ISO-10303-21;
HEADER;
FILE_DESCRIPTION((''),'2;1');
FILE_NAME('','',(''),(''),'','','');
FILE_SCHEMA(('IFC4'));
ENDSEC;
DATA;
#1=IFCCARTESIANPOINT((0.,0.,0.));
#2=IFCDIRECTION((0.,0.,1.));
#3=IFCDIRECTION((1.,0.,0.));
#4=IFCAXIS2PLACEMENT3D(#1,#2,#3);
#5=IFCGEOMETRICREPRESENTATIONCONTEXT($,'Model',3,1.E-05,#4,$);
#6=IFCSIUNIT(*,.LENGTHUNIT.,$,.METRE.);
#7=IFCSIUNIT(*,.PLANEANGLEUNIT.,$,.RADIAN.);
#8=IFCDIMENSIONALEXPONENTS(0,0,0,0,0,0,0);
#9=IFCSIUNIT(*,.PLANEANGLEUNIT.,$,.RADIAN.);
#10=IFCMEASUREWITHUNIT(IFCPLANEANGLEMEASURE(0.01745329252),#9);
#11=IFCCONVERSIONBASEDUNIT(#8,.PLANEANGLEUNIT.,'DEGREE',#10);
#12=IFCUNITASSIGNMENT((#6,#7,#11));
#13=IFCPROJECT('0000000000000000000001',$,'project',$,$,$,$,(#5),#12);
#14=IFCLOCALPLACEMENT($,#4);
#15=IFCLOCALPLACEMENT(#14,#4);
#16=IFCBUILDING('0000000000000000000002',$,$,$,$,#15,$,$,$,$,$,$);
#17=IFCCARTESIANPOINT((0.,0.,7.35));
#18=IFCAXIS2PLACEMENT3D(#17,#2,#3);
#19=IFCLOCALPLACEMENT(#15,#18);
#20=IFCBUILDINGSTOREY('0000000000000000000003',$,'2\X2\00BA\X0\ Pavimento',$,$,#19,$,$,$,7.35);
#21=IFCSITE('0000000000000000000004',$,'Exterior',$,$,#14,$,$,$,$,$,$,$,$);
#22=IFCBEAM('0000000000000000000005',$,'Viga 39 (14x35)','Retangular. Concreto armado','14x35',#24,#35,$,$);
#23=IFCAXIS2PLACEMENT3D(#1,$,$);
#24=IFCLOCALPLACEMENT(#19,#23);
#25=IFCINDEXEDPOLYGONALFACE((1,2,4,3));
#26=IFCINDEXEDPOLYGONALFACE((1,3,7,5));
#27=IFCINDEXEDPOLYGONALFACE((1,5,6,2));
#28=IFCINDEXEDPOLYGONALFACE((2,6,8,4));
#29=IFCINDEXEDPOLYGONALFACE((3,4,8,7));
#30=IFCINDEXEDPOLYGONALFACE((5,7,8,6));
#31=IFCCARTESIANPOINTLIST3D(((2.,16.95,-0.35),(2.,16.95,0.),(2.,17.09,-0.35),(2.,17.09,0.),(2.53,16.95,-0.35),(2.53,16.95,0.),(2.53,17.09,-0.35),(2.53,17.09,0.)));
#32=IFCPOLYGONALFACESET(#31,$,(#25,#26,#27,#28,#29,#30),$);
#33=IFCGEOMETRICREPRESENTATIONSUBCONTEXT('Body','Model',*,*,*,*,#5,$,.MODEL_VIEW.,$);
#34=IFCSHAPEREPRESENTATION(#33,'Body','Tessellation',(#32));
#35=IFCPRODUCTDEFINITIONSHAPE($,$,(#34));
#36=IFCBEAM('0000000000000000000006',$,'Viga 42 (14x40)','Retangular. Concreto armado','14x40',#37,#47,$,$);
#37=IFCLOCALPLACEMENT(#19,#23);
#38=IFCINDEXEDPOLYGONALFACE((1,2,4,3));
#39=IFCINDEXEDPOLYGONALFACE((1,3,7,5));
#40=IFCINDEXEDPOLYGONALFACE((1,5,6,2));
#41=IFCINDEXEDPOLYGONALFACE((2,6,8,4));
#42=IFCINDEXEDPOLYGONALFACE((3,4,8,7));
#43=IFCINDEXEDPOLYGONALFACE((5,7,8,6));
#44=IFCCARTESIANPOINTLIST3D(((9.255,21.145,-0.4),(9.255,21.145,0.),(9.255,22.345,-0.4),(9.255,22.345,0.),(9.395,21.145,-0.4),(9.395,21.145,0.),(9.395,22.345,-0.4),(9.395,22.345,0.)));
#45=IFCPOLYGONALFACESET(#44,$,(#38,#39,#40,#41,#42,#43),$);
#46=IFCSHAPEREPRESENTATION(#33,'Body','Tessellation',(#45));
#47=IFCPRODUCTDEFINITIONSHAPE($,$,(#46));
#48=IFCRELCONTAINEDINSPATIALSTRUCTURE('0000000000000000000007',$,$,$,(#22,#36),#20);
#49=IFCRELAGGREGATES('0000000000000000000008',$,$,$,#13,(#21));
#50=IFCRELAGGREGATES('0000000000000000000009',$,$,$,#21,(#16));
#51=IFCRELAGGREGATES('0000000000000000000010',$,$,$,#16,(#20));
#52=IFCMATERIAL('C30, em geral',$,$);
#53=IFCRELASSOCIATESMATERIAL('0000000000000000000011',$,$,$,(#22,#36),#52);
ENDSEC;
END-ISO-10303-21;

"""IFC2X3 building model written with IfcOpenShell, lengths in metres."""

from ifc_helpers import new_model, entity, si_unit, converted_unit, frame, frame_2d, origin_with_axes, place, context, subcontext, project, spatial, rectangle, extrude, material, element, save


model = new_model("IFC2X3")

# Units and contexts
model_context = context("Model", 3, precision=1e-05, world=origin_with_axes())
body_context = subcontext(model_context, "Body", "Model", "MODEL_VIEW")
ifc_project = project(units=[si_unit("LENGTHUNIT", "METRE"), si_unit("PLANEANGLEUNIT", "RADIAN"), converted_unit("PLANEANGLEUNIT", "DEGREE", entity("IfcPlaneAngleMeasure", 0.01745329252), si_unit("PLANEANGLEUNIT", "RADIAN"), dimensions=[0, 0, 0, 0, 0, 0, 0])], contexts=[model_context])

# Site, building, storey
site_placement = place(None, origin_with_axes())
site = spatial("IfcSite", under=ifc_project, at=site_placement, Name="Exterior")
building_placement = place(site_placement, origin_with_axes())
building = spatial("IfcBuilding", under=site, at=building_placement)
storey_placement = place(building_placement, frame((0.0, 0.0, 7.35), z_axis=(0.0, 0.0, 1.0), x_axis=(1.0, 0.0, 0.0)))
storey = spatial("IfcBuildingStorey", under=building, at=storey_placement, Name="2º Pavimento", Elevation=7.35)

# Beams
ifc_material_1 = material(Name="C30, em geral")
for number, where, z_axis, x_axis, name in (
    (1, (2.0, 17.02, 0.0), (1.0, 0.0, 0.0), (0.0, 1.0, 0.0), "Viga 39 (14x35)"),
):
    element("IfcBeam", number, at=place(storey_placement, frame(where, z_axis=z_axis, x_axis=x_axis)), inside=storey, material=ifc_material_1, Name=name, Description="Retangular. Concreto armado", ObjectType="14x35", context=body_context, shape_type="SweptSolid", body=[
        extrude(rectangle(XDim=0.14, YDim=0.35, at=frame_2d((0.0, -0.175), x_axis=(1.0, 0.0))), origin_with_axes(), (0.0, 0.0, 1.0), 0.53),
    ])
beam_1_placement = place(storey_placement, frame((9.325, 21.145, 0.0), z_axis=(0.0, 1.0, 0.0), x_axis=(-1.0, 0.0, 0.0)))
element("IfcBeam", 2, at=beam_1_placement, inside=storey, material=ifc_material_1, Name="Viga 42 (14x40)", Description="Retangular. Concreto armado", ObjectType="14x40", context=body_context, shape_type="SweptSolid", body=[
    extrude(rectangle(XDim=0.14, YDim=0.4, at=frame_2d((0.0, -0.2), x_axis=(1.0, 0.0))), origin_with_axes(), (0.0, 0.0, 1.0), 1.2),
])

save(model, "model.ifc")
